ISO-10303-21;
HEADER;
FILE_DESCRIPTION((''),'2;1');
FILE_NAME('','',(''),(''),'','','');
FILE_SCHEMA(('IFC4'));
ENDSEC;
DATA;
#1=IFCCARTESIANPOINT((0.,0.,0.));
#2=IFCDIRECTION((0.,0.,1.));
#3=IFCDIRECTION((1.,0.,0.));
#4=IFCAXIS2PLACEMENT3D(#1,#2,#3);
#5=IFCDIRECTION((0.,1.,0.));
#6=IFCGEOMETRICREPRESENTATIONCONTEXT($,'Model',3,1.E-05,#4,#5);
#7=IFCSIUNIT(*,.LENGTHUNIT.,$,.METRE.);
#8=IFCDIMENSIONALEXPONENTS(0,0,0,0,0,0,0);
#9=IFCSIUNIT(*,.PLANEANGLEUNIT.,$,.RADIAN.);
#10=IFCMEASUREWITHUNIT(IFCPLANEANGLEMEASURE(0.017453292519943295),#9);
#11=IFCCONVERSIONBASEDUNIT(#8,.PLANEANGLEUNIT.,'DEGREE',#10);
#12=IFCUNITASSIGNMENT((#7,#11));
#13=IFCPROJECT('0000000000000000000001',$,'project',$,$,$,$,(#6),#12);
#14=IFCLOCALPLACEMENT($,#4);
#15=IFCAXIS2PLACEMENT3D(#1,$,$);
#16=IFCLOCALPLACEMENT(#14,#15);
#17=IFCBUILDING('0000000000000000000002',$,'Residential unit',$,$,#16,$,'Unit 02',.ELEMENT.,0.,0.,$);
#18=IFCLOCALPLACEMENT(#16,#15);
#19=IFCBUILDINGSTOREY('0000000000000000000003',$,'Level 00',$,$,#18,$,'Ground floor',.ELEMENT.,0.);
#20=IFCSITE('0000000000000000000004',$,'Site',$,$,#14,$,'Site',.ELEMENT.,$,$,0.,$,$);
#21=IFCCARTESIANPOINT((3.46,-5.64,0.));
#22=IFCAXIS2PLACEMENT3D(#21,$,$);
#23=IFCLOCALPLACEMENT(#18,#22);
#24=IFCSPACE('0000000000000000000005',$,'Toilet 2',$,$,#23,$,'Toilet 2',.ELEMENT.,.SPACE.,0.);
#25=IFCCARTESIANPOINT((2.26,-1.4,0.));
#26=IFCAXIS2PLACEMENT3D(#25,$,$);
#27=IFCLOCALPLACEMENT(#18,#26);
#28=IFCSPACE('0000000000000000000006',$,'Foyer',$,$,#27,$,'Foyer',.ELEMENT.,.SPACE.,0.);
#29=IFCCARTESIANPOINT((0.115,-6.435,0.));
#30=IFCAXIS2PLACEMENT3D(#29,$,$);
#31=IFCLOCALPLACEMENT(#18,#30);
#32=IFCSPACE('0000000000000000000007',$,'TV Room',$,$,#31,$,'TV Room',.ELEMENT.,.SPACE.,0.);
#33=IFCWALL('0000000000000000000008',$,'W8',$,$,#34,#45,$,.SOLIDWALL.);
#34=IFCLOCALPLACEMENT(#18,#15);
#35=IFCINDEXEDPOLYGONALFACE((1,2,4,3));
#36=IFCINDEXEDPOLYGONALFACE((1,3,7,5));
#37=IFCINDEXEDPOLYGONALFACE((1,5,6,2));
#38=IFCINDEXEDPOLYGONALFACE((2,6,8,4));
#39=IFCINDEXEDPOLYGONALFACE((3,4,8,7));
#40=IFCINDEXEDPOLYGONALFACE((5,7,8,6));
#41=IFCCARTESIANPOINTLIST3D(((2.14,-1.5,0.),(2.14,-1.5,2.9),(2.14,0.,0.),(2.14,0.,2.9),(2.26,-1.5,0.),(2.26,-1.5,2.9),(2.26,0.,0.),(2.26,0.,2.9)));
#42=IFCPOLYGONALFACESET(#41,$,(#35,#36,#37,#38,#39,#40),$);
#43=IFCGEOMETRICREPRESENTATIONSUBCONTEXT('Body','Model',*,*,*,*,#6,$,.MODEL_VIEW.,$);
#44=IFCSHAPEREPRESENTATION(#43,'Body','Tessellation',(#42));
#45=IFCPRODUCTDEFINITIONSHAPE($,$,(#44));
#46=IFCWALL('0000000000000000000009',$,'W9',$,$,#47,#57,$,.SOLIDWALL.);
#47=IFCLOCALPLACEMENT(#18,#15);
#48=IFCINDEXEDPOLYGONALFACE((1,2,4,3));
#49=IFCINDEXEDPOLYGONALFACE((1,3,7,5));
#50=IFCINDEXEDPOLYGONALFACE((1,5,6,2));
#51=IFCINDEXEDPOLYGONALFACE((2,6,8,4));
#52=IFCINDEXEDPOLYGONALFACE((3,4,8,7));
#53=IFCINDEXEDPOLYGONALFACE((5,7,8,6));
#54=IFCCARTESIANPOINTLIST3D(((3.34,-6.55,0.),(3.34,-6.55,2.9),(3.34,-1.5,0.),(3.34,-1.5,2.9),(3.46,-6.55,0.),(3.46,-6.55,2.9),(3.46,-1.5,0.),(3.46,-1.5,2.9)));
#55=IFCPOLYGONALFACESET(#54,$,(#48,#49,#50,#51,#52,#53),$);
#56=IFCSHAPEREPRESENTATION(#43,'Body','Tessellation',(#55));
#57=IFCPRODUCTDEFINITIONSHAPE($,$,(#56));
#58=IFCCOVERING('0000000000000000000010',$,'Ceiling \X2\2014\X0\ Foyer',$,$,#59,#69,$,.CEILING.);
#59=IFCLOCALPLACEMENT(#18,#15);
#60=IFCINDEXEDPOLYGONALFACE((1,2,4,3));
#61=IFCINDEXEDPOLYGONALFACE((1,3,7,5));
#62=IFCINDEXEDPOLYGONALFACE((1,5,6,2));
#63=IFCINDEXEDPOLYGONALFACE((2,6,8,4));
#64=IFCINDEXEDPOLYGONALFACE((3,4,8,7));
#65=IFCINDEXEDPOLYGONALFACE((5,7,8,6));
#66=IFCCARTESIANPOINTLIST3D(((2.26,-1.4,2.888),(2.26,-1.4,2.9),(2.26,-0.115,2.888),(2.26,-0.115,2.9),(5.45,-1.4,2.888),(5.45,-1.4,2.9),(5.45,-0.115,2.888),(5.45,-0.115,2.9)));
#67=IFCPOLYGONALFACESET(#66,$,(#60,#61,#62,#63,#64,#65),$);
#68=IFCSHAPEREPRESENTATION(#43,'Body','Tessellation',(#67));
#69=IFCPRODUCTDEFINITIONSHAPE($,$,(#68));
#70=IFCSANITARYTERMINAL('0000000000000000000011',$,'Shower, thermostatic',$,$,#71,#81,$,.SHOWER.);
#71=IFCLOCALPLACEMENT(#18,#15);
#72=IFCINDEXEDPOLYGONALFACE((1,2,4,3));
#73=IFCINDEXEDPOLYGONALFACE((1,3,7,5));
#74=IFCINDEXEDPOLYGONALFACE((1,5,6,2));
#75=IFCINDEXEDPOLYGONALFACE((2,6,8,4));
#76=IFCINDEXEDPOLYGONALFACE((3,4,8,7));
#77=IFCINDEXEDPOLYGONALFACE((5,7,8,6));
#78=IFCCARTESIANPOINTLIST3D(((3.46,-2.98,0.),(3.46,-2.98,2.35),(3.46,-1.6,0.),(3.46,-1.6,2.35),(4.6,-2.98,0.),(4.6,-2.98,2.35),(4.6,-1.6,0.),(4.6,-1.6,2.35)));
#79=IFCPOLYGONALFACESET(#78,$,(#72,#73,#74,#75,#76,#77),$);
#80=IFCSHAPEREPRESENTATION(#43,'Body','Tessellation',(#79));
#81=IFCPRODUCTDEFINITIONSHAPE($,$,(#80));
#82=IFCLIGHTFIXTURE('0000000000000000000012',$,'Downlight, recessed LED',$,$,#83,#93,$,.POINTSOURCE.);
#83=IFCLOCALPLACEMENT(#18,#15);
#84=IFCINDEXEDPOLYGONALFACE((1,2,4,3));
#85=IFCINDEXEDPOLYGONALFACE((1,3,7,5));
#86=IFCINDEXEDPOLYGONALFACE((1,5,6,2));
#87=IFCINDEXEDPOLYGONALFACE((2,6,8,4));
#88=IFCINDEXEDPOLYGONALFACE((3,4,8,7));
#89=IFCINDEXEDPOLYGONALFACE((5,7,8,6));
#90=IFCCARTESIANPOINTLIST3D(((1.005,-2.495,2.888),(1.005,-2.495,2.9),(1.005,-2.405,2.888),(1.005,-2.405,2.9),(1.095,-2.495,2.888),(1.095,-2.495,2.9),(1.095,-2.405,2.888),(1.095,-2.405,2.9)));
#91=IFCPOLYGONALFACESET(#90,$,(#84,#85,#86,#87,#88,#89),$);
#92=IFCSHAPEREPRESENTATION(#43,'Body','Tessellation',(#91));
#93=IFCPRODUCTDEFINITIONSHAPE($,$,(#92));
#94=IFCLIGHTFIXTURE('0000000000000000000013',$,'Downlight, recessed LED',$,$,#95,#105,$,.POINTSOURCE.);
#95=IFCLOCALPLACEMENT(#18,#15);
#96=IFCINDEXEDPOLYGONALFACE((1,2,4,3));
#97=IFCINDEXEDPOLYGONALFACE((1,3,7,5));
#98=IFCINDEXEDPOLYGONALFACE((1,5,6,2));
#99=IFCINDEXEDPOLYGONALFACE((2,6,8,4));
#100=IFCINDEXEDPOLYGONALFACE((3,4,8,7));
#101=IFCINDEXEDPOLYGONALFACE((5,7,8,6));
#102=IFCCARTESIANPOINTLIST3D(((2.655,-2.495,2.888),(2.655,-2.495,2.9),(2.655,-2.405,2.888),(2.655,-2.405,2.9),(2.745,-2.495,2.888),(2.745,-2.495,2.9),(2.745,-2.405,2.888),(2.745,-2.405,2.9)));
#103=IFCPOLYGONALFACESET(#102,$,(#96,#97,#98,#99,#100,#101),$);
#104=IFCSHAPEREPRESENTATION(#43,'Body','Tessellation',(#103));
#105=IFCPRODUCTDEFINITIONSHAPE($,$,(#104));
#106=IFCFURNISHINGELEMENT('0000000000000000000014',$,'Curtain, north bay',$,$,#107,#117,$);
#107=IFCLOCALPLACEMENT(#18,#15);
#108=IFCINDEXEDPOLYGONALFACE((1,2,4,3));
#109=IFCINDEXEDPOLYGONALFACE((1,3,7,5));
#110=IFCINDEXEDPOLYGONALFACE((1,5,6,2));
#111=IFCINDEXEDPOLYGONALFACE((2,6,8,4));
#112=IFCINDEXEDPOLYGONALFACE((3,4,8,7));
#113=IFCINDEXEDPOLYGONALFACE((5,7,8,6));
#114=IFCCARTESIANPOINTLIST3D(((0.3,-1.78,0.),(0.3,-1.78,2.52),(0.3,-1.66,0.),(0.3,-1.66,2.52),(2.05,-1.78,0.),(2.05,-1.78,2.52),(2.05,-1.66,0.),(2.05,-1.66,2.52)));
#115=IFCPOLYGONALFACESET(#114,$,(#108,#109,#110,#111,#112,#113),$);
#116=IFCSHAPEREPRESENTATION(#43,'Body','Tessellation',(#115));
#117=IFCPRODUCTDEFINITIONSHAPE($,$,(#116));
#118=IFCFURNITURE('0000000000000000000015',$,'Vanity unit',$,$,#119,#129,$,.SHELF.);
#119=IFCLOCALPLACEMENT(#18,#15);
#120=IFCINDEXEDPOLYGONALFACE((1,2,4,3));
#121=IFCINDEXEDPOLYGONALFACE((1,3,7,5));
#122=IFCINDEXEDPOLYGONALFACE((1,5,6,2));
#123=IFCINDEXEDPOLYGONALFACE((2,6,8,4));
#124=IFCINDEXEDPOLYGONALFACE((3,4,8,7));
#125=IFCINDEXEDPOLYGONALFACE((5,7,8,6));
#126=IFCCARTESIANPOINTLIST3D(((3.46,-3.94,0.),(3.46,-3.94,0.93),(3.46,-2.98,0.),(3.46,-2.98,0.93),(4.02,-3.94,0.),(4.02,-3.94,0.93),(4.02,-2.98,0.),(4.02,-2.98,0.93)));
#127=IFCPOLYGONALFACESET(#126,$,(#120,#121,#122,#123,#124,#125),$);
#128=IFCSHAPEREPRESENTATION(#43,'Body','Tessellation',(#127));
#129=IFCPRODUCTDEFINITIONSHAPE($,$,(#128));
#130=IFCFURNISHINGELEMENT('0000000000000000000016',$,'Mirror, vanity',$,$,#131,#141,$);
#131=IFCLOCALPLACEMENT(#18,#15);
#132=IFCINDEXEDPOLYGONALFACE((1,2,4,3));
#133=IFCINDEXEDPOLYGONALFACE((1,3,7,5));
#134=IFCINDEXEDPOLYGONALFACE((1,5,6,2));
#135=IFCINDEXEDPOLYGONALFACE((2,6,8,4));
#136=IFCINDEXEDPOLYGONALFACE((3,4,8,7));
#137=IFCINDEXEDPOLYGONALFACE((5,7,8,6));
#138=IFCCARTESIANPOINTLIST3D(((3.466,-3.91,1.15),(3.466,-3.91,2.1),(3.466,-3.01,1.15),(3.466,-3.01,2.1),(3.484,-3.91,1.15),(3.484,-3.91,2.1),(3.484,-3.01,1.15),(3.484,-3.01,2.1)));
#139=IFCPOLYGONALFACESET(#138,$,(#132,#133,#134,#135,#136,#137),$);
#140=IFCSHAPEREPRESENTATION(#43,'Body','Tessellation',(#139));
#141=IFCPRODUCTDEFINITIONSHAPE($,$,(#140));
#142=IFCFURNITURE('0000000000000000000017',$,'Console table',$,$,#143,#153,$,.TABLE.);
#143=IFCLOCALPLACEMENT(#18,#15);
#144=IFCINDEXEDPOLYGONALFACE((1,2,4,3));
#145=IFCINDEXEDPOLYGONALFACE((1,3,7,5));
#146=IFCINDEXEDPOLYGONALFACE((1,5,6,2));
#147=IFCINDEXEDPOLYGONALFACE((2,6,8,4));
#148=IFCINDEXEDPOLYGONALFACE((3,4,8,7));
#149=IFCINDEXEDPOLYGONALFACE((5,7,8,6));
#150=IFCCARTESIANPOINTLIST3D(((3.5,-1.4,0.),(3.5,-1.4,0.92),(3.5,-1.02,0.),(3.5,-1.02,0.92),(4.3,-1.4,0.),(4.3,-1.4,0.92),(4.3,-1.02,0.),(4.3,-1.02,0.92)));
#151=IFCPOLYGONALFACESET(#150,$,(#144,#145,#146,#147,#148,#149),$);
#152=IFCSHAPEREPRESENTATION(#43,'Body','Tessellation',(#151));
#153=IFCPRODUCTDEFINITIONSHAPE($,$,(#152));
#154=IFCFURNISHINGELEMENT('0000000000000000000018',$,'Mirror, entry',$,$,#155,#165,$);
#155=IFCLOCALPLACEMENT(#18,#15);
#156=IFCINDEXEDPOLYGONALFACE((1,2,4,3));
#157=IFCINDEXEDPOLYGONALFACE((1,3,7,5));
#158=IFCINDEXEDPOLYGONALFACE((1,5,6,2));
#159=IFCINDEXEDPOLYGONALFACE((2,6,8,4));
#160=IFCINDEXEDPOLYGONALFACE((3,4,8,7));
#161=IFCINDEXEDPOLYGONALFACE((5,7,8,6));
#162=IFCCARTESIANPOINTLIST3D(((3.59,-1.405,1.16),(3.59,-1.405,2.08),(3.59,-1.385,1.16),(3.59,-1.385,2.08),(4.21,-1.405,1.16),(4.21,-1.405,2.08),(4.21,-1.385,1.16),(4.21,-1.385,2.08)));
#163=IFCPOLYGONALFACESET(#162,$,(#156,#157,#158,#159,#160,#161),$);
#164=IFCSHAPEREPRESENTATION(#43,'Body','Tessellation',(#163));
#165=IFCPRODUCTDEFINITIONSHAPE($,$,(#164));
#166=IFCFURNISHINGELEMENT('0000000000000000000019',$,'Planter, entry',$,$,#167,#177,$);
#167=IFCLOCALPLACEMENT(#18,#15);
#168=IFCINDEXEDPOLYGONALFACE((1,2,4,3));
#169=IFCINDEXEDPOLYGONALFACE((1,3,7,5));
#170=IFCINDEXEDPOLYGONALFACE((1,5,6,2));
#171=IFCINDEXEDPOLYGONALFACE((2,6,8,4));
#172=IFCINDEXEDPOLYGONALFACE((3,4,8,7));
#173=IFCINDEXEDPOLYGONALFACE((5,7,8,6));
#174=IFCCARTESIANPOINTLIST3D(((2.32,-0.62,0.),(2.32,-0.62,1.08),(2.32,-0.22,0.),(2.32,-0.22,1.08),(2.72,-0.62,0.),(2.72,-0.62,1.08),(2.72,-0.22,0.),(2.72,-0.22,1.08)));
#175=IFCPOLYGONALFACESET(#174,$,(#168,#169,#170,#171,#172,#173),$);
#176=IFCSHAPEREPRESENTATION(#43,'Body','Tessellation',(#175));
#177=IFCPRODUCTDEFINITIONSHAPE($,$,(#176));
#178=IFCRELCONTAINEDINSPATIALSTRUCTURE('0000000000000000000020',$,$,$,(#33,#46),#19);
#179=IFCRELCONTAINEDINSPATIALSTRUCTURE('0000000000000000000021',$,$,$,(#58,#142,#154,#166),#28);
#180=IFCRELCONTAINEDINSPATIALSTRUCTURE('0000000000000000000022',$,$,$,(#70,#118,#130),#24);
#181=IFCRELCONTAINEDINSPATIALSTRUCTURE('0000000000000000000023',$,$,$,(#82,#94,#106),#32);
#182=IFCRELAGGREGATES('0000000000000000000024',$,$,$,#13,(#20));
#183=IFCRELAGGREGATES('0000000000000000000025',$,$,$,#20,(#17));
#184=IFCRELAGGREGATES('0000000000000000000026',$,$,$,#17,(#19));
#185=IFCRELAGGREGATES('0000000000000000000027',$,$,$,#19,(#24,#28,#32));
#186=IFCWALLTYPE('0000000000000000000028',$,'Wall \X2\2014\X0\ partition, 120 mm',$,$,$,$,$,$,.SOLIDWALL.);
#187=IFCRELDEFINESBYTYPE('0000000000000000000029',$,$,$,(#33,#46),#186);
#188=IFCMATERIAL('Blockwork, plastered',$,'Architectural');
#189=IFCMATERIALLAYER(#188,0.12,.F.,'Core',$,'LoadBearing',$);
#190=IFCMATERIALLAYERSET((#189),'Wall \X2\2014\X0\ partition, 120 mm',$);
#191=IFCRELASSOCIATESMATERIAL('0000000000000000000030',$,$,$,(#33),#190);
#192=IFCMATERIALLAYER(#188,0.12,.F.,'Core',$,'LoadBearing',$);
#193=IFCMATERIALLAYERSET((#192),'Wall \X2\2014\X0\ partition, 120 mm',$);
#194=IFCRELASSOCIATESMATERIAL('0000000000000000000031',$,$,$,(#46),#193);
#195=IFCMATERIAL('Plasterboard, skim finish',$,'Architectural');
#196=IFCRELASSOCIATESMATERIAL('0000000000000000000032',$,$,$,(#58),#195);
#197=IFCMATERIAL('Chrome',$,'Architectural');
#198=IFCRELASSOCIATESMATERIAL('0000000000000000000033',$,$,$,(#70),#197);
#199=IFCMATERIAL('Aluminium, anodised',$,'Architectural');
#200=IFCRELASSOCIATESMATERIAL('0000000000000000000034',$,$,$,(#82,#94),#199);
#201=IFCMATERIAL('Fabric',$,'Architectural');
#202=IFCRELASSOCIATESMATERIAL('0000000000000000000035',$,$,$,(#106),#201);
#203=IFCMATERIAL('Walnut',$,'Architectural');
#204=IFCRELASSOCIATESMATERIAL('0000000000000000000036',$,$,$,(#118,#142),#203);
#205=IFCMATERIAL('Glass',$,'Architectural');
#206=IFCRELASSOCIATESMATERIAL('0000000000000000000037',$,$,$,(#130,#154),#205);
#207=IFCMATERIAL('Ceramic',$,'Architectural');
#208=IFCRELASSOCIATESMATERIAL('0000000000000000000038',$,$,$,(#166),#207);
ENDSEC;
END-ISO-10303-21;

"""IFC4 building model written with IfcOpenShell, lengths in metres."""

from ifc_helpers import new_model, entity, si_unit, converted_unit, direction, frame, frame_2d, origin, origin_with_axes, place, context, subcontext, project, spatial, rectangle, extrude, material, layer, layer_set, layer_usage, type_object, element, save


model = new_model("IFC4")

# Units and contexts
model_context = context("Model", 3, precision=1e-05, world=origin_with_axes(), true_north=direction((0.0, 1.0, 0.0)))
body_context = subcontext(model_context, "Body", "Model", "MODEL_VIEW")
ifc_project = project(units=[si_unit("LENGTHUNIT", "METRE"), converted_unit("PLANEANGLEUNIT", "DEGREE", entity("IfcPlaneAngleMeasure", 0.017453292519943295), si_unit("PLANEANGLEUNIT", "RADIAN"), dimensions=[0, 0, 0, 0, 0, 0, 0])], contexts=[model_context])

# Site, building, storey, space
site_placement = place(None, origin_with_axes())
site = spatial("IfcSite", under=ifc_project, at=site_placement, Name="Site", LongName="Site", CompositionType="ELEMENT", RefElevation=0.0)
building_placement = place(site_placement, origin())
building = spatial("IfcBuilding", under=site, at=building_placement, Name="Residential unit", LongName="Unit 02", CompositionType="ELEMENT", ElevationOfRefHeight=0.0, ElevationOfTerrain=0.0)
storey_placement = place(building_placement, origin())
storey = spatial("IfcBuildingStorey", under=building, at=storey_placement, Name="Level 00", LongName="Ground floor", CompositionType="ELEMENT", Elevation=0.0)
space_1_placement = place(storey_placement, frame((3.46, -5.64, 0.0)))
space_1 = spatial("IfcSpace", under=storey, at=space_1_placement, Name="Toilet 2", LongName="Toilet 2", CompositionType="ELEMENT", PredefinedType="SPACE", ElevationWithFlooring=0.0)

# Shared definitions
ifc_material_1 = material(Name="Glass", Category="Architectural")

# Shared definitions
ifc_material_2 = material(Name="Blockwork, plastered", Category="Architectural")

# Walls
ifc_layer_1 = layer(ifc_material_2, 0.12, ventilated=False, Name="Core", Category="LoadBearing")
ifc_layer_set_1 = layer_set([ifc_layer_1], Name="Wall — partition, 120 mm")
ifc_layer_usage_1 = layer_usage(ifc_layer_set_1, "AXIS2", "POSITIVE", -0.06)
wall_type_1 = type_object("IfcWallType", Name="Wall — partition, 120 mm", PredefinedType="SOLIDWALL")
wall_1_placement = place(storey_placement, frame((2.2, 0.0, 0.0), z_axis=(0.0, 0.0, 1.0), x_axis=(0.0, -1.0, 0.0)))
element("IfcWall", 1, at=wall_1_placement, inside=storey, type_object=wall_type_1, material=ifc_layer_usage_1, Name="W8", PredefinedType="SOLIDWALL", context=body_context, shape_type="SweptSolid", body=[
    extrude(rectangle(XDim=1.5, YDim=0.12, at=frame_2d((0.75, 0.0))), origin(), (0.0, 0.0, 1.0), 2.9),
])
ifc_layer_2 = layer(ifc_material_2, 0.12, ventilated=False, Name="Core", Category="LoadBearing")
ifc_layer_set_2 = layer_set([ifc_layer_2], Name="Wall — partition, 120 mm")
ifc_layer_usage_2 = layer_usage(ifc_layer_set_2, "AXIS2", "POSITIVE", -0.06)
wall_2_placement = place(storey_placement, frame((3.4, -1.5, 0.0), z_axis=(0.0, 0.0, 1.0), x_axis=(0.0, -1.0, 0.0)))
element("IfcWall", 2, at=wall_2_placement, inside=storey, type_object=wall_type_1, material=ifc_layer_usage_2, Name="W9", PredefinedType="SOLIDWALL", context=body_context, shape_type="SweptSolid", body=[
    extrude(rectangle(XDim=5.05, YDim=0.12, at=frame_2d((2.525, 0.0))), origin(), (0.0, 0.0, 1.0), 2.9),
])

# Shared definitions
space_2_placement = place(storey_placement, frame((2.26, -1.4, 0.0)))
space_2 = spatial("IfcSpace", under=storey, at=space_2_placement, Name="Foyer", LongName="Foyer", CompositionType="ELEMENT", PredefinedType="SPACE", ElevationWithFlooring=0.0)

# Covering
ifc_material_3 = material(Name="Plasterboard, skim finish", Category="Architectural")
covering_placement = place(storey_placement, frame((2.26, -1.4, 2.888)))
element("IfcCovering", 3, at=covering_placement, inside=space_2, material=ifc_material_3, Name="Ceiling — Foyer", PredefinedType="CEILING", context=body_context, shape_type="SweptSolid", body=[
    extrude(rectangle(XDim=3.19, YDim=1.285, at=frame_2d((1.595, 0.6425))), origin(), (0.0, 0.0, 1.0), 0.012),
])

# Sanitary terminal
ifc_material_4 = material(Name="Chrome", Category="Architectural")
sanitary_terminal_placement = place(storey_placement, frame((3.46, -2.98, 0.0)))
element("IfcSanitaryTerminal", 4, at=sanitary_terminal_placement, inside=space_1, material=ifc_material_4, Name="Shower, thermostatic", PredefinedType="SHOWER", context=body_context, shape_type="SweptSolid", body=[
    extrude(rectangle(XDim=1.14, YDim=1.38, at=frame_2d((0.57, 0.69))), origin(), (0.0, 0.0, 1.0), 2.35),
])

# Shared definitions
space_3_placement = place(storey_placement, frame((0.115, -6.435, 0.0)))
space_3 = spatial("IfcSpace", under=storey, at=space_3_placement, Name="TV Room", LongName="TV Room", CompositionType="ELEMENT", PredefinedType="SPACE", ElevationWithFlooring=0.0)

# Light fixtures
ifc_material_5 = material(Name="Aluminium, anodised", Category="Architectural")
for number, where, name in (
    (5, (1.005, -2.495, 2.888), "Downlight, recessed LED"),
    (6, (2.655, -2.495, 2.888), "Downlight, recessed LED"),
):
    element("IfcLightFixture", number, at=place(storey_placement, frame(where)), inside=space_3, material=ifc_material_5, Name=name, PredefinedType="POINTSOURCE", context=body_context, shape_type="SweptSolid", body=[
        extrude(rectangle(XDim=0.09, YDim=0.09, at=frame_2d((0.045, 0.045))), origin(), (0.0, 0.0, 1.0), 0.012),
    ])

# Furnishing element
ifc_material_6 = material(Name="Fabric", Category="Architectural")
furnishing_1_placement = place(storey_placement, frame((0.3, -1.78, 0.0)))
element("IfcFurnishingElement", 7, at=furnishing_1_placement, inside=space_3, material=ifc_material_6, Name="Curtain, north bay", context=body_context, shape_type="SweptSolid", body=[
    extrude(rectangle(XDim=1.75, YDim=0.12, at=frame_2d((0.875, 0.06))), origin(), (0.0, 0.0, 1.0), 2.52),
])

# Furniture
ifc_material_7 = material(Name="Walnut", Category="Architectural")
furniture_1_placement = place(storey_placement, frame((3.46, -3.94, 0.0)))
element("IfcFurniture", 8, at=furniture_1_placement, inside=space_1, material=ifc_material_7, Name="Vanity unit", PredefinedType="SHELF", context=body_context, shape_type="SweptSolid", body=[
    extrude(rectangle(XDim=0.56, YDim=0.96, at=frame_2d((0.28, 0.48))), origin(), (0.0, 0.0, 1.0), 0.93),
])

# Furnishing element
furnishing_2_placement = place(storey_placement, frame((3.466, -3.91, 1.15)))
element("IfcFurnishingElement", 9, at=furnishing_2_placement, inside=space_1, material=ifc_material_1, Name="Mirror, vanity", context=body_context, shape_type="SweptSolid", body=[
    extrude(rectangle(XDim=0.018, YDim=0.9, at=frame_2d((0.009, 0.45))), origin(), (0.0, 0.0, 1.0), 0.95),
])

# Furniture
furniture_2_placement = place(storey_placement, frame((3.5, -1.4, 0.0)))
element("IfcFurniture", 10, at=furniture_2_placement, inside=space_2, material=ifc_material_7, Name="Console table", PredefinedType="TABLE", context=body_context, shape_type="SweptSolid", body=[
    extrude(rectangle(XDim=0.8, YDim=0.38, at=frame_2d((0.4, 0.19))), origin(), (0.0, 0.0, 1.0), 0.92),
])

# Furnishing elements
furnishing_3_placement = place(storey_placement, frame((3.59, -1.405, 1.16)))
element("IfcFurnishingElement", 11, at=furnishing_3_placement, inside=space_2, material=ifc_material_1, Name="Mirror, entry", context=body_context, shape_type="SweptSolid", body=[
    extrude(rectangle(XDim=0.62, YDim=0.02, at=frame_2d((0.31, 0.01))), origin(), (0.0, 0.0, 1.0), 0.92),
])
ifc_material_8 = material(Name="Ceramic", Category="Architectural")
furnishing_4_placement = place(storey_placement, frame((2.32, -0.62, 0.0)))
element("IfcFurnishingElement", 12, at=furnishing_4_placement, inside=space_2, material=ifc_material_8, Name="Planter, entry", context=body_context, shape_type="SweptSolid", body=[
    extrude(rectangle(XDim=0.4, YDim=0.4, at=frame_2d((0.2, 0.2))), origin(), (0.0, 0.0, 1.0), 1.08),
])

save(model, "model.ifc")
